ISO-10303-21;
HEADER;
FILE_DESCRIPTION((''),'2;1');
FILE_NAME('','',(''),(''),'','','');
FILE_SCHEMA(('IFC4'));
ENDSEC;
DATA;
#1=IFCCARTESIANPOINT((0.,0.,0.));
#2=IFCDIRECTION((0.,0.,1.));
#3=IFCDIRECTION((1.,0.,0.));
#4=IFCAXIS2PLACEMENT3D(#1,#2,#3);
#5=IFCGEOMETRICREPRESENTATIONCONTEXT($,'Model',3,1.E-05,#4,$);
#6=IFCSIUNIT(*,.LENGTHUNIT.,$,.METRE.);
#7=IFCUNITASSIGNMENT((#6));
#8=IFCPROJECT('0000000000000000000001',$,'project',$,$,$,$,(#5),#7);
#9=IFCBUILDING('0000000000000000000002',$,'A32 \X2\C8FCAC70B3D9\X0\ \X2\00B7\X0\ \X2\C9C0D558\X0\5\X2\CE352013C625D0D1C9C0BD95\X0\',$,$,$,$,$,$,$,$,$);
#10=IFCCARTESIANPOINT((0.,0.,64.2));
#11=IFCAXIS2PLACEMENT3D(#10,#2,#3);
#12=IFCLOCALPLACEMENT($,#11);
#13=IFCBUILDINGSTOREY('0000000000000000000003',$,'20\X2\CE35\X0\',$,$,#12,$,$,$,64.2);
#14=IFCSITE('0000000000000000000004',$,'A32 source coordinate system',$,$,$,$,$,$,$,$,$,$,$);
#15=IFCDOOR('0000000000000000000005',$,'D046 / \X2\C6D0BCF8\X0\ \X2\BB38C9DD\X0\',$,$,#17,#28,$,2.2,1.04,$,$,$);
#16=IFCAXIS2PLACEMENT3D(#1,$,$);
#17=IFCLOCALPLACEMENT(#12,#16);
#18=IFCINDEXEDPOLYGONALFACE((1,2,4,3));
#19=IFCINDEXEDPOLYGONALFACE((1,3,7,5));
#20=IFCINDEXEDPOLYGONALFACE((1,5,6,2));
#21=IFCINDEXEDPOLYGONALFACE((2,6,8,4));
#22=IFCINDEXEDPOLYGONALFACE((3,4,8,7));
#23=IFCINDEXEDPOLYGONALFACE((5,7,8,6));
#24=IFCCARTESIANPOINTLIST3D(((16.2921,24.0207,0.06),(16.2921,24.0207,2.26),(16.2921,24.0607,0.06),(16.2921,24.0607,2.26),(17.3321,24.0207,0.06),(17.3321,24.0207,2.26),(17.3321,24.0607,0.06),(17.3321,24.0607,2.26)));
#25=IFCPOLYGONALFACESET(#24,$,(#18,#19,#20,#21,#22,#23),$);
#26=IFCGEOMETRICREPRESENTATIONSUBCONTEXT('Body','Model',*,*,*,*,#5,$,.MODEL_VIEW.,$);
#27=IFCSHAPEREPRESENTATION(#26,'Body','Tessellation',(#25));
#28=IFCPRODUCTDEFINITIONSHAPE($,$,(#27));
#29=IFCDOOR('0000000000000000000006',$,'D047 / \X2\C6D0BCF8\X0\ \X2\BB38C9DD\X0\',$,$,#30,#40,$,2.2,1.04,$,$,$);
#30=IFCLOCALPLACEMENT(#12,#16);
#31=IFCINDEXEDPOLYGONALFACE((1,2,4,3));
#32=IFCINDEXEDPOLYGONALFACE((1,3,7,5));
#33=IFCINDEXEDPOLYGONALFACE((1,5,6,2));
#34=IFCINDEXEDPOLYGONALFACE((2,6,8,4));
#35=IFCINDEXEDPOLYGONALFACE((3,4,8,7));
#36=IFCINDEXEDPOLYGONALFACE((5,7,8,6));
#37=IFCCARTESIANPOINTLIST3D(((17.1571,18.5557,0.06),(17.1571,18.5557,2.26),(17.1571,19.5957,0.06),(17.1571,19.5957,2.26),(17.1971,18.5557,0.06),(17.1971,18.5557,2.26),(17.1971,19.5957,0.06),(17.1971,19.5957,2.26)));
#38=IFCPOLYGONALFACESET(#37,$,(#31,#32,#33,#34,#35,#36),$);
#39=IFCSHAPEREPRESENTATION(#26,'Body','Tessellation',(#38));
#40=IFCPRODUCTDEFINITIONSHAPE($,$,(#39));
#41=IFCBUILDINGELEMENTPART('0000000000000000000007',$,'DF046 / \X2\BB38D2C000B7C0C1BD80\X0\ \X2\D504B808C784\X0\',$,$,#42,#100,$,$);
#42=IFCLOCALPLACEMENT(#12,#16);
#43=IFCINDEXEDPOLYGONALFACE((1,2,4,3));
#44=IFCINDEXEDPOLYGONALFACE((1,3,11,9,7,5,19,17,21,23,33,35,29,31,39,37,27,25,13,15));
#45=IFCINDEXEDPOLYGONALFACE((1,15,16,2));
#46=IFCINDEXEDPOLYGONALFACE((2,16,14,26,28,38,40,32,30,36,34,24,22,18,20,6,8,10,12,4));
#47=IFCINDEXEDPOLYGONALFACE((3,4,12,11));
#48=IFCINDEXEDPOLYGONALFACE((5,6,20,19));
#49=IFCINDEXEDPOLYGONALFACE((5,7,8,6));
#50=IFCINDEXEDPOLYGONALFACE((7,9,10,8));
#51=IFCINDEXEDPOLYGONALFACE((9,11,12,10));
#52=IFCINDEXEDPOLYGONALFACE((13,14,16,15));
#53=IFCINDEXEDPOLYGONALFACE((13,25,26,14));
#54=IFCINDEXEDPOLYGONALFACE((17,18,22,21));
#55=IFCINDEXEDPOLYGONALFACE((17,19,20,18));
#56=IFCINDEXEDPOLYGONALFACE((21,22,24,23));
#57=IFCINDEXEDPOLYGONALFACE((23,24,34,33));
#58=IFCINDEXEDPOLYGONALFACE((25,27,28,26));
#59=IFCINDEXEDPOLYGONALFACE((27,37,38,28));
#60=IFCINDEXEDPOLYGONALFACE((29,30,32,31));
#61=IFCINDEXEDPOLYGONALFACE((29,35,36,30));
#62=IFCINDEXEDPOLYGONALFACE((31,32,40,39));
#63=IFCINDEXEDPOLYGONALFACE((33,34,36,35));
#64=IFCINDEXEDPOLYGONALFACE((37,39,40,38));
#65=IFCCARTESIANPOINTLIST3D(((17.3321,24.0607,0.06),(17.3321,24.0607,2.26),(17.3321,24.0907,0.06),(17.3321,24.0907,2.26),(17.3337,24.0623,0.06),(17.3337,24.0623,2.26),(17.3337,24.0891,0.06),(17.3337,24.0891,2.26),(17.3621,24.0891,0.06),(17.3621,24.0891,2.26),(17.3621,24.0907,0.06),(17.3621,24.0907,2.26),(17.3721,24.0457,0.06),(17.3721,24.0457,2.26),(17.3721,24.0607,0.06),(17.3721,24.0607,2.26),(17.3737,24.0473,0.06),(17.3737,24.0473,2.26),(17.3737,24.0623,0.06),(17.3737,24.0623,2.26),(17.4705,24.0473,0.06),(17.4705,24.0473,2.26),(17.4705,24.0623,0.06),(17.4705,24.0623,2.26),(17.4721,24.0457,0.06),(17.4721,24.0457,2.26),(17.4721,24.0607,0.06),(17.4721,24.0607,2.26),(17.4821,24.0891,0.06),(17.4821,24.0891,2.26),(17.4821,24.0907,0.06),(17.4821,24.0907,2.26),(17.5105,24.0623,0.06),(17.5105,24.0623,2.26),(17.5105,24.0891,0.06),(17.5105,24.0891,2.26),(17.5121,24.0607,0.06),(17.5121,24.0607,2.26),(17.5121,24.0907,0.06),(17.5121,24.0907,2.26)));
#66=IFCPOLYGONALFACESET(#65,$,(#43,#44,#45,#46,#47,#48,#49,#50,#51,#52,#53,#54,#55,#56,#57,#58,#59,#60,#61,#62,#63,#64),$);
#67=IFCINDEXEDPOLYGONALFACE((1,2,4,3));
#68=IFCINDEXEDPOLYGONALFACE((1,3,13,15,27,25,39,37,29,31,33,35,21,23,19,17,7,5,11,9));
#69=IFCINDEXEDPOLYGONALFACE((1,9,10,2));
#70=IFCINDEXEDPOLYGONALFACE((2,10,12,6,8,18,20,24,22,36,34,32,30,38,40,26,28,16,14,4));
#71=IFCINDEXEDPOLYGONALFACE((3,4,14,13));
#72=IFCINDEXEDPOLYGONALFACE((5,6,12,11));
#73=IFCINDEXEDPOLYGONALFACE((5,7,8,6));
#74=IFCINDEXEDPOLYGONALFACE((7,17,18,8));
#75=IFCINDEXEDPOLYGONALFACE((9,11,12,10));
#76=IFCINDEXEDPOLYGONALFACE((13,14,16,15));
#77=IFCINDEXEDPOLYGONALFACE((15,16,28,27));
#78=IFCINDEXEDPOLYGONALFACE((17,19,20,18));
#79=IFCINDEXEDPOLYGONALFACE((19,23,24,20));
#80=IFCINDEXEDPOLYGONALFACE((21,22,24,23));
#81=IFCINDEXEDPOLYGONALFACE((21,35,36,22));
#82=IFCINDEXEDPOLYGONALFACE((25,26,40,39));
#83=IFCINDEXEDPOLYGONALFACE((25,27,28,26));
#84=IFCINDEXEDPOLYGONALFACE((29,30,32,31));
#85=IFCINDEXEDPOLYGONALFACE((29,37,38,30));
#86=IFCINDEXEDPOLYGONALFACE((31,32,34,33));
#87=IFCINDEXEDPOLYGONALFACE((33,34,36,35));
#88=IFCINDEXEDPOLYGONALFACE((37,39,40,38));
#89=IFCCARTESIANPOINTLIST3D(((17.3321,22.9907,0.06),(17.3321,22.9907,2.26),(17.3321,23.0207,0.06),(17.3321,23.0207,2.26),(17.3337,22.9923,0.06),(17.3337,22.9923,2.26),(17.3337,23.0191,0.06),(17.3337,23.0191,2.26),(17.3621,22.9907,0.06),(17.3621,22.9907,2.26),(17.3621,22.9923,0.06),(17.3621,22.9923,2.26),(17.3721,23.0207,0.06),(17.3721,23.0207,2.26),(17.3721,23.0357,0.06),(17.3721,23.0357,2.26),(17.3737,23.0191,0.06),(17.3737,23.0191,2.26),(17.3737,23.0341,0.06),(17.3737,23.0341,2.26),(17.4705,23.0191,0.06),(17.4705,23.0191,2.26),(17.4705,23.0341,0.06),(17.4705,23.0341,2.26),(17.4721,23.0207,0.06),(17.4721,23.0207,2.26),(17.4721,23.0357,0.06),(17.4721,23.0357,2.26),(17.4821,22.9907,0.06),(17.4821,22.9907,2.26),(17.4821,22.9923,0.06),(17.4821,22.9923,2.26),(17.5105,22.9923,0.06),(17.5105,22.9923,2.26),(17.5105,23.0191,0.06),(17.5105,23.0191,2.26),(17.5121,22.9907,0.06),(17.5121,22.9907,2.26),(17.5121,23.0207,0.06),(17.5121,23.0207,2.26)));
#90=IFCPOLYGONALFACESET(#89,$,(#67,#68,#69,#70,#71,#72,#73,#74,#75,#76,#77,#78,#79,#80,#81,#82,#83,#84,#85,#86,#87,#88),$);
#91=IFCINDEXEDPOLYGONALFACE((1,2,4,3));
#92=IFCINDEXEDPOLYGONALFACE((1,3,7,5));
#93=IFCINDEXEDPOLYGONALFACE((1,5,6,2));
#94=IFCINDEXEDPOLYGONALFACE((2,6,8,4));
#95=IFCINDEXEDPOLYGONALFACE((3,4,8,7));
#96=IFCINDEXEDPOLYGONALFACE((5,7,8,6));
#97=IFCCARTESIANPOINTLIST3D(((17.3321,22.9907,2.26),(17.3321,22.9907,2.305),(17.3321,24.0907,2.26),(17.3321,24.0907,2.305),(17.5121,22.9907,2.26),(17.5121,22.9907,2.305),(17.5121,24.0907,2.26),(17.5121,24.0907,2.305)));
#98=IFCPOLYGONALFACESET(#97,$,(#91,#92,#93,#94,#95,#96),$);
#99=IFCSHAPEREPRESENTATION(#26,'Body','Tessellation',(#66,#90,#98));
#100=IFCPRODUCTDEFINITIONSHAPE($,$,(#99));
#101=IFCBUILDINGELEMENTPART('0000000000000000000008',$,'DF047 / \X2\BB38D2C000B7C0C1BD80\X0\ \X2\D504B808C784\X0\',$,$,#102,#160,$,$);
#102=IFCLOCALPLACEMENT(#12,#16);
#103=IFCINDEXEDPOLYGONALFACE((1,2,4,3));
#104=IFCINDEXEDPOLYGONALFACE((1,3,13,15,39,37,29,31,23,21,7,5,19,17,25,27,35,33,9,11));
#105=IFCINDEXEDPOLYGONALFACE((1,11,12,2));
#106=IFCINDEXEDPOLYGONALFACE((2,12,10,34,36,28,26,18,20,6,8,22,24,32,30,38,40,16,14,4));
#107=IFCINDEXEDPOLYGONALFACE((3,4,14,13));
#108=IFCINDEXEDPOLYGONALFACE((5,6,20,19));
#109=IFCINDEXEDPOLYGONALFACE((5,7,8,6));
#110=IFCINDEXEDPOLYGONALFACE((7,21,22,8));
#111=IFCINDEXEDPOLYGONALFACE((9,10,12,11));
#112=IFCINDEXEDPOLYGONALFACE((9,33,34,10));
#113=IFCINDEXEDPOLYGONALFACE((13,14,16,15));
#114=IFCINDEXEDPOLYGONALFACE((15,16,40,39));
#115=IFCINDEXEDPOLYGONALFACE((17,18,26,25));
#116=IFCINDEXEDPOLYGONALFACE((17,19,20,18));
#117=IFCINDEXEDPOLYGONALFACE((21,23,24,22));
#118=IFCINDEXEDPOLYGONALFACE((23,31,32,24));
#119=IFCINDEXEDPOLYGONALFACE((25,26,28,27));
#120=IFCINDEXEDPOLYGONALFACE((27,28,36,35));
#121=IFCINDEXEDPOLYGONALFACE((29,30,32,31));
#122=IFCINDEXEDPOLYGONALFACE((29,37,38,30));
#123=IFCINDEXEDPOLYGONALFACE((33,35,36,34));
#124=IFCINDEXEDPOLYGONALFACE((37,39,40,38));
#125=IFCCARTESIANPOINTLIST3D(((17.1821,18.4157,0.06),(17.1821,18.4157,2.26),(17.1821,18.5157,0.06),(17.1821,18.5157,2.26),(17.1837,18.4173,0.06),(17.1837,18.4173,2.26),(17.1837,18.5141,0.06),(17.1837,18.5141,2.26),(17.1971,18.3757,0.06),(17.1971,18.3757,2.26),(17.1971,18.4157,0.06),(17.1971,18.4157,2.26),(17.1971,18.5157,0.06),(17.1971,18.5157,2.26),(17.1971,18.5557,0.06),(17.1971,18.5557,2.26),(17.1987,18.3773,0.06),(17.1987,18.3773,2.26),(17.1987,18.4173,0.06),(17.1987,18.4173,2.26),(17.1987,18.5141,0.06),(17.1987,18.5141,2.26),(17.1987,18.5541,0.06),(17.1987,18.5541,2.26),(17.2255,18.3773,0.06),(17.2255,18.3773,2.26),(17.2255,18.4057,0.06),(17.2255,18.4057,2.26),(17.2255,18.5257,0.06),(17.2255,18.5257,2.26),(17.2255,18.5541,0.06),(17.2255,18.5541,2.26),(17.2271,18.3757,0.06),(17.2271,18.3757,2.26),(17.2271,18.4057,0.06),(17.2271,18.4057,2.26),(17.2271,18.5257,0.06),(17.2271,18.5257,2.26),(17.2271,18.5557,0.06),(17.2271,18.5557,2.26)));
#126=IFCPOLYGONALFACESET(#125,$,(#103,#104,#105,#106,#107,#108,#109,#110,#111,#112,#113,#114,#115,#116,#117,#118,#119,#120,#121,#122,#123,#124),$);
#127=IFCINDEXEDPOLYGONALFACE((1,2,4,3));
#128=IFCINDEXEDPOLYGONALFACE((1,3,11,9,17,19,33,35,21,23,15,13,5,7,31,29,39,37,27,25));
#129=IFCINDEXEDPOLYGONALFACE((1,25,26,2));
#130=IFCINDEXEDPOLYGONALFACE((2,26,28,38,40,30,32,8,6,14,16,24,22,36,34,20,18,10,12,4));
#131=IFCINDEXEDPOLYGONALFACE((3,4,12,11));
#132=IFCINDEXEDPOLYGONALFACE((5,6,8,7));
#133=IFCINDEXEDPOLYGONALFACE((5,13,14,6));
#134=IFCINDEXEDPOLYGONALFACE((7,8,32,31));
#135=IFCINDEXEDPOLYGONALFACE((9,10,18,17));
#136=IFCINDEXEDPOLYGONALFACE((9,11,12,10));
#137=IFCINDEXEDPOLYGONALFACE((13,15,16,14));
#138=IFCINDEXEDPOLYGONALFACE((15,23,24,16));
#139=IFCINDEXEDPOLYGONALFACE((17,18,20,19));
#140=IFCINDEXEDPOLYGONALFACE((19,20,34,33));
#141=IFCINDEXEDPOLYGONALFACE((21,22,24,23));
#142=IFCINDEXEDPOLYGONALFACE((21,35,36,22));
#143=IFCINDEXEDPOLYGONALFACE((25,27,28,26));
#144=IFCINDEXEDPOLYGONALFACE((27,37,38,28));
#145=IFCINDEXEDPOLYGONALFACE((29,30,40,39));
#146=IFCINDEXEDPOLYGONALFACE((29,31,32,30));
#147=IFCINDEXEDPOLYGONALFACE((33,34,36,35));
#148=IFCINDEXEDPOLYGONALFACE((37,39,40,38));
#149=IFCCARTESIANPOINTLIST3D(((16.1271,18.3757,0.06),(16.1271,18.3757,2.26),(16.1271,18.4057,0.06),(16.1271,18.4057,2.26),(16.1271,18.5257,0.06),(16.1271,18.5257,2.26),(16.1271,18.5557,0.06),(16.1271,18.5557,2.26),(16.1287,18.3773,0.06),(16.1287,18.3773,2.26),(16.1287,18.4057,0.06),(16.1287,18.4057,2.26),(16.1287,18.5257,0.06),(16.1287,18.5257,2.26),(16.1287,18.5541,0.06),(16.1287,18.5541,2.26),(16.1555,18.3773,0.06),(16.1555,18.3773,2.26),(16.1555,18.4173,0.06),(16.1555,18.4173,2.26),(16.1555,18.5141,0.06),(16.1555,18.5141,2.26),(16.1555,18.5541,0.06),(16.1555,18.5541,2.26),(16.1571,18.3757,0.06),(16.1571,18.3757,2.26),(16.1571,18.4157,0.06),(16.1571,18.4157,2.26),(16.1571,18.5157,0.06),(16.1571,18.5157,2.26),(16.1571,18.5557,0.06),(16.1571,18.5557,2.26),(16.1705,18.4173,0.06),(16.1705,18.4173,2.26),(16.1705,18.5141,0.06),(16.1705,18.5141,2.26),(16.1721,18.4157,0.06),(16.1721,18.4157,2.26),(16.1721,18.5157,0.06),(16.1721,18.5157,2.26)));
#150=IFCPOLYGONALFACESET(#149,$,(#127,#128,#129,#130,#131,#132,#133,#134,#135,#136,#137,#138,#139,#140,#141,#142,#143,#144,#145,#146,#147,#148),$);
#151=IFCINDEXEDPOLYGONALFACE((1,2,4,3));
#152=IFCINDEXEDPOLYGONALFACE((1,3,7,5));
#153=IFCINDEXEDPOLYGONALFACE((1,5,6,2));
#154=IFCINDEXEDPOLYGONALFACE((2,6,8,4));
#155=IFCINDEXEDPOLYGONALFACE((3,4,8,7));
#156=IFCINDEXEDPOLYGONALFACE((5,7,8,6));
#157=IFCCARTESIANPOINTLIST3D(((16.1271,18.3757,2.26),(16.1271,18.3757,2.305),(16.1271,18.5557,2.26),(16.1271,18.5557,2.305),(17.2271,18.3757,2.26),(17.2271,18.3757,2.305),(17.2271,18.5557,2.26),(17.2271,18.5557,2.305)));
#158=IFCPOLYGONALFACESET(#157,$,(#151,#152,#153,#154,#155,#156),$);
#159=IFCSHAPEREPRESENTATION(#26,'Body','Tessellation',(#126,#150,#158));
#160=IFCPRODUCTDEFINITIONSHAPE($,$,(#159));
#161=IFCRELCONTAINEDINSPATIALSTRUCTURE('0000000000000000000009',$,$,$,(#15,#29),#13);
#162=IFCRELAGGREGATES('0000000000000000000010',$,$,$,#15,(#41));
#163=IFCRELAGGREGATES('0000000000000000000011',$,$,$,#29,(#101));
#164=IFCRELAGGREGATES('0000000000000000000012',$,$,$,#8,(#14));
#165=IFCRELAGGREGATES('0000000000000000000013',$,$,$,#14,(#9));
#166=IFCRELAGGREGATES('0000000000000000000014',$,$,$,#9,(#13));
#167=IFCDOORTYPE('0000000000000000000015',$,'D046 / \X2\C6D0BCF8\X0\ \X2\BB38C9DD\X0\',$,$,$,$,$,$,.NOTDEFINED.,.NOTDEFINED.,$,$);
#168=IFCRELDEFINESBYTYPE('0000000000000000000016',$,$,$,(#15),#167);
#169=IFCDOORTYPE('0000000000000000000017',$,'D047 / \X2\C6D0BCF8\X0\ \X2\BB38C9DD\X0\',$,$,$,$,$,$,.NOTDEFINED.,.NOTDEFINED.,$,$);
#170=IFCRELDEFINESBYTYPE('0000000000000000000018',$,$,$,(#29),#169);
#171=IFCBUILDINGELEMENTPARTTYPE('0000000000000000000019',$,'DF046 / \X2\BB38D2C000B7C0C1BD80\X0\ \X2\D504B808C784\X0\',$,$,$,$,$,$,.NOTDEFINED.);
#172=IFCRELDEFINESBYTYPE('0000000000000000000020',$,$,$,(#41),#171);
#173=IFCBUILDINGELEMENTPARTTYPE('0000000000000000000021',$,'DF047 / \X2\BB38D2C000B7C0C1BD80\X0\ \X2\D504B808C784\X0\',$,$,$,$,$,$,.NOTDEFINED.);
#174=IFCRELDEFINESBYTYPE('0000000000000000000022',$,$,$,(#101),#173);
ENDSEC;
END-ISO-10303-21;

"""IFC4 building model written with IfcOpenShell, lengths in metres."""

from ifc_helpers import new_model, si_unit, frame, origin, origin_with_axes, place, context, subcontext, project, spatial, polyline, outline, extrude, source, transform, mapped, type_object, type_shapes, element, aggregate, save


model = new_model("IFC4")

# Units and contexts
model_context = context("Model", 3, precision=1e-05, world=origin_with_axes())
body_context = subcontext(model_context, "Body", "Model", "MODEL_VIEW")
ifc_project = project(units=[si_unit("LENGTHUNIT", "METRE")], contexts=[model_context])

# Site, building, storey
storey_placement = place(None, frame((0.0, 0.0, 64.2), z_axis=(0.0, 0.0, 1.0), x_axis=(1.0, 0.0, 0.0)))
site = spatial("IfcSite", under=ifc_project, Name="A32 source coordinate system")
building = spatial("IfcBuilding", under=site, Name="A32 주거동 · 지하5층–옥탑지붕")
storey = spatial("IfcBuildingStorey", under=building, at=storey_placement, Name="20층", Elevation=64.2)

# Doors
door_type_1 = type_object("IfcDoorType", Name="D046 / 원본 문짝", OperationType="NOTDEFINED", PredefinedType="NOTDEFINED")
shared_shape_1 = source(origin(), body_context, "Body", "SweptSolid", [
    extrude(outline(polyline([(17.3321, 24.0607), (17.3321, 24.0207), (16.2921, 24.0207), (16.2921, 24.0607), (17.3321, 24.0607)])), frame((0.0, 0.0, 0.06)), (0.0, 0.0, 1.0), 2.2),
])
type_shapes(door_type_1, [shared_shape_1])
door_1_placement = place(storey_placement, origin_with_axes())
door_1 = element("IfcDoor", 1, at=door_1_placement, inside=storey, type_object=door_type_1, Name="D046 / 원본 문짝", OverallHeight=2.2, OverallWidth=1.04, context=body_context, shape_type="MappedRepresentation", body=[
    mapped(shared_shape_1, transform((0.0, 0.0, 0.0), scale=1.0)),
])
door_type_2 = type_object("IfcDoorType", Name="D047 / 원본 문짝", OperationType="NOTDEFINED", PredefinedType="NOTDEFINED")
shared_shape_2 = source(origin(), body_context, "Body", "SweptSolid", [
    extrude(outline(polyline([(17.1971, 18.5557), (17.1571, 18.5557), (17.1571, 19.5957), (17.1971, 19.5957), (17.1971, 18.5557)])), frame((0.0, 0.0, 0.06)), (0.0, 0.0, 1.0), 2.2),
])
type_shapes(door_type_2, [shared_shape_2])
door_2_placement = place(storey_placement, origin_with_axes())
door_2 = element("IfcDoor", 2, at=door_2_placement, inside=storey, type_object=door_type_2, Name="D047 / 원본 문짝", OverallHeight=2.2, OverallWidth=1.04, context=body_context, shape_type="MappedRepresentation", body=[
    mapped(shared_shape_2, transform((0.0, 0.0, 0.0), scale=1.0)),
])

# Building element parts
building_element_part_type_1 = type_object("IfcBuildingElementPartType", Name="DF046 / 문틀·상부 프레임", PredefinedType="NOTDEFINED")
shared_shape_3 = source(origin(), body_context, "Body", "SweptSolid", [
    extrude(outline(polyline([(17.3337, 24.0891), (17.3337, 24.0623), (17.3737, 24.0623), (17.3737, 24.0473), (17.4705, 24.0473), (17.4705, 24.0623), (17.5105, 24.0623), (17.5105, 24.0891), (17.4821, 24.0891), (17.4821, 24.0907), (17.5121, 24.0907), (17.5121, 24.0607), (17.4721, 24.0607), (17.4721, 24.0457), (17.3721, 24.0457), (17.3721, 24.0607), (17.3321, 24.0607), (17.3321, 24.0907), (17.3621, 24.0907), (17.3621, 24.0891), (17.3337, 24.0891)])), frame((0.0, 0.0, 0.06)), (0.0, 0.0, 1.0), 2.2),
    extrude(outline(polyline([(17.3621, 22.9907), (17.3321, 22.9907), (17.3321, 23.0207), (17.3721, 23.0207), (17.3721, 23.0357), (17.4721, 23.0357), (17.4721, 23.0207), (17.5121, 23.0207), (17.5121, 22.9907), (17.4821, 22.9907), (17.4821, 22.9923), (17.5105, 22.9923), (17.5105, 23.0191), (17.4705, 23.0191), (17.4705, 23.0341), (17.3737, 23.0341), (17.3737, 23.0191), (17.3337, 23.0191), (17.3337, 22.9923), (17.3621, 22.9923), (17.3621, 22.9907)])), frame((0.0, 0.0, 0.06)), (0.0, 0.0, 1.0), 2.2),
    extrude(outline(polyline([(17.3321, 22.9907), (17.3321, 24.0907), (17.5121, 24.0907), (17.5121, 22.9907), (17.3321, 22.9907)])), frame((0.0, 0.0, 2.26)), (0.0, 0.0, 1.0), 0.045),
])
type_shapes(building_element_part_type_1, [shared_shape_3])
building_element_part_1_placement = place(door_1_placement, origin_with_axes())
building_element_part_1 = element("IfcBuildingElementPart", 3, at=building_element_part_1_placement, type_object=building_element_part_type_1, Name="DF046 / 문틀·상부 프레임", context=body_context, shape_type="MappedRepresentation", body=[
    mapped(shared_shape_3, transform((0.0, 0.0, 0.0), scale=1.0)),
])
aggregate(door_1, [building_element_part_1])
building_element_part_type_2 = type_object("IfcBuildingElementPartType", Name="DF047 / 문틀·상부 프레임", PredefinedType="NOTDEFINED")
shared_shape_4 = source(origin(), body_context, "Body", "SweptSolid", [
    extrude(outline(polyline([(17.2255, 18.5541), (17.1987, 18.5541), (17.1987, 18.5141), (17.1837, 18.5141), (17.1837, 18.4173), (17.1987, 18.4173), (17.1987, 18.3773), (17.2255, 18.3773), (17.2255, 18.4057), (17.2271, 18.4057), (17.2271, 18.3757), (17.1971, 18.3757), (17.1971, 18.4157), (17.1821, 18.4157), (17.1821, 18.5157), (17.1971, 18.5157), (17.1971, 18.5557), (17.2271, 18.5557), (17.2271, 18.5257), (17.2255, 18.5257), (17.2255, 18.5541)])), frame((0.0, 0.0, 0.06)), (0.0, 0.0, 1.0), 2.2),
    extrude(outline(polyline([(16.1271, 18.5257), (16.1271, 18.5557), (16.1571, 18.5557), (16.1571, 18.5157), (16.1721, 18.5157), (16.1721, 18.4157), (16.1571, 18.4157), (16.1571, 18.3757), (16.1271, 18.3757), (16.1271, 18.4057), (16.1287, 18.4057), (16.1287, 18.3773), (16.1555, 18.3773), (16.1555, 18.4173), (16.1705, 18.4173), (16.1705, 18.5141), (16.1555, 18.5141), (16.1555, 18.5541), (16.1287, 18.5541), (16.1287, 18.5257), (16.1271, 18.5257)])), frame((0.0, 0.0, 0.06)), (0.0, 0.0, 1.0), 2.2),
    extrude(outline(polyline([(16.1271, 18.3757), (16.1271, 18.5557), (17.2271, 18.5557), (17.2271, 18.3757), (16.1271, 18.3757)])), frame((0.0, 0.0, 2.26)), (0.0, 0.0, 1.0), 0.045),
])
type_shapes(building_element_part_type_2, [shared_shape_4])
building_element_part_2_placement = place(door_2_placement, origin_with_axes())
building_element_part_2 = element("IfcBuildingElementPart", 4, at=building_element_part_2_placement, type_object=building_element_part_type_2, Name="DF047 / 문틀·상부 프레임", context=body_context, shape_type="MappedRepresentation", body=[
    mapped(shared_shape_4, transform((0.0, 0.0, 0.0), scale=1.0)),
])
aggregate(door_2, [building_element_part_2])

save(model, "model.ifc")
